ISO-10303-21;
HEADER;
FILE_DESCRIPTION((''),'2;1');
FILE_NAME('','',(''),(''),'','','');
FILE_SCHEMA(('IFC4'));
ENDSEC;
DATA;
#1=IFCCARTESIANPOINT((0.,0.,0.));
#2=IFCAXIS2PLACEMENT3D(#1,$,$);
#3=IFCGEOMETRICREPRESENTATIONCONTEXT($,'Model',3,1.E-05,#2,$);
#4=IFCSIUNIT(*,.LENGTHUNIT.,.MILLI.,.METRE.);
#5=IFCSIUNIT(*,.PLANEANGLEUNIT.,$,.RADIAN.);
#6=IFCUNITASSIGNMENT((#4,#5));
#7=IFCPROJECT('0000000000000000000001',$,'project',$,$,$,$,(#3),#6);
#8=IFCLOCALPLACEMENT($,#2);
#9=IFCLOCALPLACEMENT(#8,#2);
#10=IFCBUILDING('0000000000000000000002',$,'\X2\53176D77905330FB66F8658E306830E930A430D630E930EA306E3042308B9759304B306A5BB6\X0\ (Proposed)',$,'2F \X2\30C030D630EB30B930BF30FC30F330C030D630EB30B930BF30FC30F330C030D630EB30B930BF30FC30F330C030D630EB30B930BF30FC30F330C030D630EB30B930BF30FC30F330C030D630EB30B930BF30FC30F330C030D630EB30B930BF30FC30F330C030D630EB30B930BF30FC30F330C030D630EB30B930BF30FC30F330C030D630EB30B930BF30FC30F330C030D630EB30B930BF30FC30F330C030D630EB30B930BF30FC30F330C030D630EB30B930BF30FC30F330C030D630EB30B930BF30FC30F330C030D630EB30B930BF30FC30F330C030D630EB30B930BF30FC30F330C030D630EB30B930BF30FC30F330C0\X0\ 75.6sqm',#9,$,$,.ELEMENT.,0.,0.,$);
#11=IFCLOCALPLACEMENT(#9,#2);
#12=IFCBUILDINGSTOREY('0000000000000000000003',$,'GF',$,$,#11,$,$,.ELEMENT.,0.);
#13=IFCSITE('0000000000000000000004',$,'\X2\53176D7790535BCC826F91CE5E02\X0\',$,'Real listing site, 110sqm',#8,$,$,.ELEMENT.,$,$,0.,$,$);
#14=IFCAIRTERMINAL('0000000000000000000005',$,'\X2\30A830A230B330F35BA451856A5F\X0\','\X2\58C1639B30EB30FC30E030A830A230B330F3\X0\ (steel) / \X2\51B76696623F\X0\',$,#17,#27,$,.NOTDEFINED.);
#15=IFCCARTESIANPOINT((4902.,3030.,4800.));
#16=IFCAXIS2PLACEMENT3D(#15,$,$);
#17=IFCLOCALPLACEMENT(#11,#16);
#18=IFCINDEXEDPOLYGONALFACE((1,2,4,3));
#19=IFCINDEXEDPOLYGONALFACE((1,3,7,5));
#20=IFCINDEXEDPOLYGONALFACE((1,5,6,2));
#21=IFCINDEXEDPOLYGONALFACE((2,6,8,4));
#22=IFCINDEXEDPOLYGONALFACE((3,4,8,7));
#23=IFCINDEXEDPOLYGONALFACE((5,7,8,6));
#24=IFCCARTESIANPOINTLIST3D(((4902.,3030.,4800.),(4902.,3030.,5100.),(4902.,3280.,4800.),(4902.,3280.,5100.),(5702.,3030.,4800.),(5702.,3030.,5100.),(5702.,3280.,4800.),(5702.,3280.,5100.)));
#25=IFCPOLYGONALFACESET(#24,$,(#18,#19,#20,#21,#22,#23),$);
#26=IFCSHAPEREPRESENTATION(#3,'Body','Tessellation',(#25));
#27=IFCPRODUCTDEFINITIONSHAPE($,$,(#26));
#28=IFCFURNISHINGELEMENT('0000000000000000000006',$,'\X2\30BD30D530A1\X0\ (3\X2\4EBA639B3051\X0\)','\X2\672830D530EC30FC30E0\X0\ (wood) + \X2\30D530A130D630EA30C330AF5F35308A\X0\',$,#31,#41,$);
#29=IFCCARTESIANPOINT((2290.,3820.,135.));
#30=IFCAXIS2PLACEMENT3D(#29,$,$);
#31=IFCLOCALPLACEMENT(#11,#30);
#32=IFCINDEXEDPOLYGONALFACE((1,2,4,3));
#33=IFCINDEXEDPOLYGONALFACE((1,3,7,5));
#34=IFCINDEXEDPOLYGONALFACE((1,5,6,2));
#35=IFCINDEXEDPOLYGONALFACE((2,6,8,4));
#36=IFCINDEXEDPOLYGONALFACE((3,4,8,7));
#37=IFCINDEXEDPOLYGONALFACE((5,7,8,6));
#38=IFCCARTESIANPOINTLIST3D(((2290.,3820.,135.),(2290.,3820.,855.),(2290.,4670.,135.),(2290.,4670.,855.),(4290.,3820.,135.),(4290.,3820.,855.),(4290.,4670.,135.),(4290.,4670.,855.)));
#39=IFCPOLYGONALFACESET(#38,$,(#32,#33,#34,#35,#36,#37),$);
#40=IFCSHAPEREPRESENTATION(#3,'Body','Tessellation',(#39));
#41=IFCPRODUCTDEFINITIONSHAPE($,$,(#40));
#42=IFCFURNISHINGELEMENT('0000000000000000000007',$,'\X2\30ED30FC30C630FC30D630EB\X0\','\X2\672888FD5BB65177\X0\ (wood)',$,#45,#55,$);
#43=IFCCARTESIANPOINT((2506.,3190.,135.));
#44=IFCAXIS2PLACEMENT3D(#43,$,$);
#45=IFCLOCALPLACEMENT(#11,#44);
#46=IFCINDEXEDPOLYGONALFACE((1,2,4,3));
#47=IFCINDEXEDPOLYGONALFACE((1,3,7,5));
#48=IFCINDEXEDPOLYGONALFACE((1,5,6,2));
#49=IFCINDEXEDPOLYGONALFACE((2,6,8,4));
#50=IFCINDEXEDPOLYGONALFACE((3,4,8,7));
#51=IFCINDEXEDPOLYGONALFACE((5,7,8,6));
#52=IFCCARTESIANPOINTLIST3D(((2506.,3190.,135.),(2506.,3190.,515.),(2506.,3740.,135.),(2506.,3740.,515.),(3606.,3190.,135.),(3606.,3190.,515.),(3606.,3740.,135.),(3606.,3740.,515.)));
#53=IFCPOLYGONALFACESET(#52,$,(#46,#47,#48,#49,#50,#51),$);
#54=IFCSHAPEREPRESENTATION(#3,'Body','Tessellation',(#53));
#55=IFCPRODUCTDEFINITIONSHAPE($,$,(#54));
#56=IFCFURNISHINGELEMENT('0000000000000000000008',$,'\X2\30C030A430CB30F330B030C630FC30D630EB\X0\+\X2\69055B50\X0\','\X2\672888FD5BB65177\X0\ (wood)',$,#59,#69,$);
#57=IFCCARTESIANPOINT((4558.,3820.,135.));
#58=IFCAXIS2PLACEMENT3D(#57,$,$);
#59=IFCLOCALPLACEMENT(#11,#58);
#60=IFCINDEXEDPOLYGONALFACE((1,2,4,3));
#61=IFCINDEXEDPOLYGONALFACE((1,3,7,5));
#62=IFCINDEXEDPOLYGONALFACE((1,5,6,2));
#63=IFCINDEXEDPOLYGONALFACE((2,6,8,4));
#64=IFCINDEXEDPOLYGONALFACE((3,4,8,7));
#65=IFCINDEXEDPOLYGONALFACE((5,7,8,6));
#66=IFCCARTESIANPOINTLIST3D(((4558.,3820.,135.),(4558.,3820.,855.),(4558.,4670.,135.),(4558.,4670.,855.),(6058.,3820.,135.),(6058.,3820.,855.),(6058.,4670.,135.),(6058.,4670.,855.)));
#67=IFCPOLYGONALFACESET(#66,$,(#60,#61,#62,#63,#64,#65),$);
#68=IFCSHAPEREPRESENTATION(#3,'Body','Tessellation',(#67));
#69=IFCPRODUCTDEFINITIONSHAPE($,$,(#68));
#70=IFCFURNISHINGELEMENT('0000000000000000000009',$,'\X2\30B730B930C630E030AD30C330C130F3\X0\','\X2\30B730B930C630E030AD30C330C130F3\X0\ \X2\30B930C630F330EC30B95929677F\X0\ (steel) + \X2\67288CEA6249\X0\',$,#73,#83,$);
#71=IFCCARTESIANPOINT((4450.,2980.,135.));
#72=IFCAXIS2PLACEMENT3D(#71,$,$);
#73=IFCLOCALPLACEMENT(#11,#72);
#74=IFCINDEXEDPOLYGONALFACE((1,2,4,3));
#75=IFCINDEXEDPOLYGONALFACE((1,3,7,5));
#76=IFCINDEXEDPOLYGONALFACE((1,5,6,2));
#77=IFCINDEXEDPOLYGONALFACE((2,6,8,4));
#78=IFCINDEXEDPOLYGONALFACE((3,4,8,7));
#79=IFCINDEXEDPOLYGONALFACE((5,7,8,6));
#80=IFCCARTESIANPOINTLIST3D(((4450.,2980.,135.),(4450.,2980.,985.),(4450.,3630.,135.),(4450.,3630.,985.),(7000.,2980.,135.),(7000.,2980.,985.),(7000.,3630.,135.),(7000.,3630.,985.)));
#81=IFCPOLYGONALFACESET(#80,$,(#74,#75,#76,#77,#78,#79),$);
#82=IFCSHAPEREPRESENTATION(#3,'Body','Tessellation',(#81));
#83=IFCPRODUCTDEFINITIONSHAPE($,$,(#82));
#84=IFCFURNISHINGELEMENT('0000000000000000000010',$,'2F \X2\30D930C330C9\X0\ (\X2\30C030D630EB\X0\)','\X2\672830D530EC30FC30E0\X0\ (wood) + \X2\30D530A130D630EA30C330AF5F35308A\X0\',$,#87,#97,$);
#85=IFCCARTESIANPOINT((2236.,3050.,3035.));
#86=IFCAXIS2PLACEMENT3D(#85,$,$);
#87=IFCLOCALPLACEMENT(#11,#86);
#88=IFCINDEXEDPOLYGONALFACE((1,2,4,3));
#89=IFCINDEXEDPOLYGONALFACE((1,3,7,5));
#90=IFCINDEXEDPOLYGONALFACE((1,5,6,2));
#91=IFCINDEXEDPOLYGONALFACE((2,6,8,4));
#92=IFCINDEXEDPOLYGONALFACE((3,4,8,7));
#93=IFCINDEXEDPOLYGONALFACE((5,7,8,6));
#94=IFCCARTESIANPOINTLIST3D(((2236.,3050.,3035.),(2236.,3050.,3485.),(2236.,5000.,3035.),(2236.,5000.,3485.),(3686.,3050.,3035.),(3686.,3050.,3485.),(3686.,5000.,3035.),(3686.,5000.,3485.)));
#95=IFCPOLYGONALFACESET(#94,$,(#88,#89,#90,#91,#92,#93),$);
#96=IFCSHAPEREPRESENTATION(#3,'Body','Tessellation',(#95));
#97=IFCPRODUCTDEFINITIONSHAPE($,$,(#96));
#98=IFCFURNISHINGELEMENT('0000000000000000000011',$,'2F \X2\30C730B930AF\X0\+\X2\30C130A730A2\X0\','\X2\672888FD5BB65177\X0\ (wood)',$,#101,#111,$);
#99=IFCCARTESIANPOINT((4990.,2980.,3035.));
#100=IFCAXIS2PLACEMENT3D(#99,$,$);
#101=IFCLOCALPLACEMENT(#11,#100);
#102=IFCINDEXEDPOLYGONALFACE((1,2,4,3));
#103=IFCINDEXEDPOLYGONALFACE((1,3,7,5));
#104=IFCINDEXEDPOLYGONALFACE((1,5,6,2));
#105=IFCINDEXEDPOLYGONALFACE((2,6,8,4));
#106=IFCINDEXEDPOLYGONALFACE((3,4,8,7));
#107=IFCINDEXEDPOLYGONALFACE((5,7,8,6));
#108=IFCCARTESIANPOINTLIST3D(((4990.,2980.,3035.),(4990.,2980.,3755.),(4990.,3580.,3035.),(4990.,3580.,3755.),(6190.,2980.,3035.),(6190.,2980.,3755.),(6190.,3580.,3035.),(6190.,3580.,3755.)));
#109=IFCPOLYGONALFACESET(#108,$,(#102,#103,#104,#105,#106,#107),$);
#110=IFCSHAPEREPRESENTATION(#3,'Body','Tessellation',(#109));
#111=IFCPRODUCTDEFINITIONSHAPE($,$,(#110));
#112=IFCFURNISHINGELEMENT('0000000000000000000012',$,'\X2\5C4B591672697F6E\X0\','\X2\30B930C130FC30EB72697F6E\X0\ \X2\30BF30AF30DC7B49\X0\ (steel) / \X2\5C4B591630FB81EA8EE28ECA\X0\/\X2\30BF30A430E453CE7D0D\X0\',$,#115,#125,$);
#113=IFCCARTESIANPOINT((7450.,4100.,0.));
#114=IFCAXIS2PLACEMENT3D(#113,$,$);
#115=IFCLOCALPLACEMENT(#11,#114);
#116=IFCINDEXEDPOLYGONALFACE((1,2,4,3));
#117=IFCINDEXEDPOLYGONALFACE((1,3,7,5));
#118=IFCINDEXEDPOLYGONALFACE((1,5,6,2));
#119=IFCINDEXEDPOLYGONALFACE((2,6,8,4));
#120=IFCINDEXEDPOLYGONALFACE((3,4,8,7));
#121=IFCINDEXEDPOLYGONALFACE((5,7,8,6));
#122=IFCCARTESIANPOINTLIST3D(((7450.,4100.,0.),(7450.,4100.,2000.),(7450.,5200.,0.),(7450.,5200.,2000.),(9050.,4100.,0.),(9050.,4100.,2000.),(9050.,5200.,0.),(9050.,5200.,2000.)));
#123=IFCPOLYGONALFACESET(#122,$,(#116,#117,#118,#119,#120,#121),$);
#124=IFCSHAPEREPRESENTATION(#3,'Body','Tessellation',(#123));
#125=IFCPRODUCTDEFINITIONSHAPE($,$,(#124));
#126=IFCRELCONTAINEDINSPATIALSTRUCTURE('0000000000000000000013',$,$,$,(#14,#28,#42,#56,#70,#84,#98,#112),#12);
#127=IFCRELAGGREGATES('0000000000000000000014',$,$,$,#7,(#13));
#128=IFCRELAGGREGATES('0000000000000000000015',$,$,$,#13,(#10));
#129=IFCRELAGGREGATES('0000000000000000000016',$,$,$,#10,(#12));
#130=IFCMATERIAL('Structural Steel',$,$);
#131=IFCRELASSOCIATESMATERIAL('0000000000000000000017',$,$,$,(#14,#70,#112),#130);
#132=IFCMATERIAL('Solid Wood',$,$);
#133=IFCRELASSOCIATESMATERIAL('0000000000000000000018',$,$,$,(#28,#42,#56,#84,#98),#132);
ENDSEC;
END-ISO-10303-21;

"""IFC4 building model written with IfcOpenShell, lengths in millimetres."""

from ifc_helpers import new_model, si_unit, frame, frame_2d, origin, place, context, project, spatial, rectangle, extrude, material, element, save


model = new_model("IFC4")

# Units and contexts
model_context = context("Model", 3, precision=1e-05, world=origin())
ifc_project = project(units=[si_unit("LENGTHUNIT", "METRE", prefix="MILLI"), si_unit("PLANEANGLEUNIT", "RADIAN")], contexts=[model_context])

# Site, building, storey
site_placement = place(None, origin())
site = spatial("IfcSite", under=ifc_project, at=site_placement, Name="北海道富良野市", ObjectType="Real listing site, 110sqm", CompositionType="ELEMENT", RefElevation=0.0)
building_placement = place(site_placement, origin())
building = spatial("IfcBuilding", under=site, at=building_placement, Name="北海道・書斎とライブラリのある静かな家 (Proposed)", ObjectType="2F ダブルスターンダブルスターンダブルスターンダブルスターンダブルスターンダブルスターンダブルスターンダブルスターンダブルスターンダブルスターンダブルスターンダブルスターンダブルスターンダブルスターンダブルスターンダブルスターンダブルスターンダ 75.6sqm", CompositionType="ELEMENT", ElevationOfRefHeight=0.0, ElevationOfTerrain=0.0)
storey_placement = place(building_placement, origin())
storey = spatial("IfcBuildingStorey", under=building, at=storey_placement, Name="GF", CompositionType="ELEMENT", Elevation=0.0)

# Shared definitions
ifc_material_1 = material(Name="Solid Wood")

# Shared definitions
ifc_material_2 = material(Name="Structural Steel")

# Air terminal
air_terminal_1_placement = place(storey_placement, frame((4902.0, 3030.0, 4800.0)))
element("IfcAirTerminal", 1, at=air_terminal_1_placement, inside=storey, material=ifc_material_2, Name="エアコン室内機", Description="壁掛ルームエアコン (steel) / 冷暖房", PredefinedType="NOTDEFINED", context=model_context, shape_type="SweptSolid", body=[
    extrude(rectangle(XDim=800.0, YDim=250.0, at=frame_2d((400.0, 125.0))), frame((4902.0, 3030.0, 4800.0)), (0.0, 0.0, 1.0), 300.0),
])

# Furnishing elements
furnishing_1_placement = place(storey_placement, frame((2290.0, 3820.0, 135.0)))
element("IfcFurnishingElement", 2, at=furnishing_1_placement, inside=storey, material=ifc_material_1, Name="ソファ (3人掛け)", Description="木フレーム (wood) + ファブリック張り", context=model_context, shape_type="SweptSolid", body=[
    extrude(rectangle(XDim=2000.0, YDim=850.0, at=frame_2d((1000.0, 425.0))), frame((2290.0, 3820.0, 135.0)), (0.0, 0.0, 1.0), 720.0),
])
furnishing_2_placement = place(storey_placement, frame((2506.0, 3190.0, 135.0)))
element("IfcFurnishingElement", 3, at=furnishing_2_placement, inside=storey, material=ifc_material_1, Name="ローテーブル", Description="木製家具 (wood)", context=model_context, shape_type="SweptSolid", body=[
    extrude(rectangle(XDim=1100.0, YDim=550.0, at=frame_2d((550.0, 275.0))), frame((2506.0, 3190.0, 135.0)), (0.0, 0.0, 1.0), 380.0),
])
furnishing_3_placement = place(storey_placement, frame((4558.0, 3820.0, 135.0)))
element("IfcFurnishingElement", 4, at=furnishing_3_placement, inside=storey, material=ifc_material_1, Name="ダイニングテーブル+椅子", Description="木製家具 (wood)", context=model_context, shape_type="SweptSolid", body=[
    extrude(rectangle(XDim=1500.0, YDim=850.0, at=frame_2d((750.0, 425.0))), frame((4558.0, 3820.0, 135.0)), (0.0, 0.0, 1.0), 720.0),
])
furnishing_4_placement = place(storey_placement, frame((4450.0, 2980.0, 135.0)))
element("IfcFurnishingElement", 5, at=furnishing_4_placement, inside=storey, material=ifc_material_2, Name="システムキッチン", Description="システムキッチン ステンレス天板 (steel) + 木質扉", context=model_context, shape_type="SweptSolid", body=[
    extrude(rectangle(XDim=2550.0, YDim=650.0, at=frame_2d((1275.0, 325.0))), frame((4450.0, 2980.0, 135.0)), (0.0, 0.0, 1.0), 850.0),
])
furnishing_5_placement = place(storey_placement, frame((2236.0, 3050.0, 3035.0)))
element("IfcFurnishingElement", 6, at=furnishing_5_placement, inside=storey, material=ifc_material_1, Name="2F ベッド (ダブル)", Description="木フレーム (wood) + ファブリック張り", context=model_context, shape_type="SweptSolid", body=[
    extrude(rectangle(XDim=1450.0, YDim=1950.0, at=frame_2d((725.0, 975.0))), frame((2236.0, 3050.0, 3035.0)), (0.0, 0.0, 1.0), 450.0),
])
furnishing_6_placement = place(storey_placement, frame((4990.0, 2980.0, 3035.0)))
element("IfcFurnishingElement", 7, at=furnishing_6_placement, inside=storey, material=ifc_material_1, Name="2F デスク+チェア", Description="木製家具 (wood)", context=model_context, shape_type="SweptSolid", body=[
    extrude(rectangle(XDim=1200.0, YDim=600.0, at=frame_2d((600.0, 300.0))), frame((4990.0, 2980.0, 3035.0)), (0.0, 0.0, 1.0), 720.0),
])
furnishing_7_placement = place(storey_placement, frame((7450.0, 4100.0, 0.0)))
element("IfcFurnishingElement", 8, at=furnishing_7_placement, inside=storey, material=ifc_material_2, Name="屋外物置", Description="スチール物置 タクボ等 (steel) / 屋外・自転車/タイヤ収納", context=model_context, shape_type="SweptSolid", body=[
    extrude(rectangle(XDim=1600.0, YDim=1100.0, at=frame_2d((800.0, 550.0))), frame((7450.0, 4100.0, 0.0)), (0.0, 0.0, 1.0), 2000.0),
])

save(model, "model.ifc")
